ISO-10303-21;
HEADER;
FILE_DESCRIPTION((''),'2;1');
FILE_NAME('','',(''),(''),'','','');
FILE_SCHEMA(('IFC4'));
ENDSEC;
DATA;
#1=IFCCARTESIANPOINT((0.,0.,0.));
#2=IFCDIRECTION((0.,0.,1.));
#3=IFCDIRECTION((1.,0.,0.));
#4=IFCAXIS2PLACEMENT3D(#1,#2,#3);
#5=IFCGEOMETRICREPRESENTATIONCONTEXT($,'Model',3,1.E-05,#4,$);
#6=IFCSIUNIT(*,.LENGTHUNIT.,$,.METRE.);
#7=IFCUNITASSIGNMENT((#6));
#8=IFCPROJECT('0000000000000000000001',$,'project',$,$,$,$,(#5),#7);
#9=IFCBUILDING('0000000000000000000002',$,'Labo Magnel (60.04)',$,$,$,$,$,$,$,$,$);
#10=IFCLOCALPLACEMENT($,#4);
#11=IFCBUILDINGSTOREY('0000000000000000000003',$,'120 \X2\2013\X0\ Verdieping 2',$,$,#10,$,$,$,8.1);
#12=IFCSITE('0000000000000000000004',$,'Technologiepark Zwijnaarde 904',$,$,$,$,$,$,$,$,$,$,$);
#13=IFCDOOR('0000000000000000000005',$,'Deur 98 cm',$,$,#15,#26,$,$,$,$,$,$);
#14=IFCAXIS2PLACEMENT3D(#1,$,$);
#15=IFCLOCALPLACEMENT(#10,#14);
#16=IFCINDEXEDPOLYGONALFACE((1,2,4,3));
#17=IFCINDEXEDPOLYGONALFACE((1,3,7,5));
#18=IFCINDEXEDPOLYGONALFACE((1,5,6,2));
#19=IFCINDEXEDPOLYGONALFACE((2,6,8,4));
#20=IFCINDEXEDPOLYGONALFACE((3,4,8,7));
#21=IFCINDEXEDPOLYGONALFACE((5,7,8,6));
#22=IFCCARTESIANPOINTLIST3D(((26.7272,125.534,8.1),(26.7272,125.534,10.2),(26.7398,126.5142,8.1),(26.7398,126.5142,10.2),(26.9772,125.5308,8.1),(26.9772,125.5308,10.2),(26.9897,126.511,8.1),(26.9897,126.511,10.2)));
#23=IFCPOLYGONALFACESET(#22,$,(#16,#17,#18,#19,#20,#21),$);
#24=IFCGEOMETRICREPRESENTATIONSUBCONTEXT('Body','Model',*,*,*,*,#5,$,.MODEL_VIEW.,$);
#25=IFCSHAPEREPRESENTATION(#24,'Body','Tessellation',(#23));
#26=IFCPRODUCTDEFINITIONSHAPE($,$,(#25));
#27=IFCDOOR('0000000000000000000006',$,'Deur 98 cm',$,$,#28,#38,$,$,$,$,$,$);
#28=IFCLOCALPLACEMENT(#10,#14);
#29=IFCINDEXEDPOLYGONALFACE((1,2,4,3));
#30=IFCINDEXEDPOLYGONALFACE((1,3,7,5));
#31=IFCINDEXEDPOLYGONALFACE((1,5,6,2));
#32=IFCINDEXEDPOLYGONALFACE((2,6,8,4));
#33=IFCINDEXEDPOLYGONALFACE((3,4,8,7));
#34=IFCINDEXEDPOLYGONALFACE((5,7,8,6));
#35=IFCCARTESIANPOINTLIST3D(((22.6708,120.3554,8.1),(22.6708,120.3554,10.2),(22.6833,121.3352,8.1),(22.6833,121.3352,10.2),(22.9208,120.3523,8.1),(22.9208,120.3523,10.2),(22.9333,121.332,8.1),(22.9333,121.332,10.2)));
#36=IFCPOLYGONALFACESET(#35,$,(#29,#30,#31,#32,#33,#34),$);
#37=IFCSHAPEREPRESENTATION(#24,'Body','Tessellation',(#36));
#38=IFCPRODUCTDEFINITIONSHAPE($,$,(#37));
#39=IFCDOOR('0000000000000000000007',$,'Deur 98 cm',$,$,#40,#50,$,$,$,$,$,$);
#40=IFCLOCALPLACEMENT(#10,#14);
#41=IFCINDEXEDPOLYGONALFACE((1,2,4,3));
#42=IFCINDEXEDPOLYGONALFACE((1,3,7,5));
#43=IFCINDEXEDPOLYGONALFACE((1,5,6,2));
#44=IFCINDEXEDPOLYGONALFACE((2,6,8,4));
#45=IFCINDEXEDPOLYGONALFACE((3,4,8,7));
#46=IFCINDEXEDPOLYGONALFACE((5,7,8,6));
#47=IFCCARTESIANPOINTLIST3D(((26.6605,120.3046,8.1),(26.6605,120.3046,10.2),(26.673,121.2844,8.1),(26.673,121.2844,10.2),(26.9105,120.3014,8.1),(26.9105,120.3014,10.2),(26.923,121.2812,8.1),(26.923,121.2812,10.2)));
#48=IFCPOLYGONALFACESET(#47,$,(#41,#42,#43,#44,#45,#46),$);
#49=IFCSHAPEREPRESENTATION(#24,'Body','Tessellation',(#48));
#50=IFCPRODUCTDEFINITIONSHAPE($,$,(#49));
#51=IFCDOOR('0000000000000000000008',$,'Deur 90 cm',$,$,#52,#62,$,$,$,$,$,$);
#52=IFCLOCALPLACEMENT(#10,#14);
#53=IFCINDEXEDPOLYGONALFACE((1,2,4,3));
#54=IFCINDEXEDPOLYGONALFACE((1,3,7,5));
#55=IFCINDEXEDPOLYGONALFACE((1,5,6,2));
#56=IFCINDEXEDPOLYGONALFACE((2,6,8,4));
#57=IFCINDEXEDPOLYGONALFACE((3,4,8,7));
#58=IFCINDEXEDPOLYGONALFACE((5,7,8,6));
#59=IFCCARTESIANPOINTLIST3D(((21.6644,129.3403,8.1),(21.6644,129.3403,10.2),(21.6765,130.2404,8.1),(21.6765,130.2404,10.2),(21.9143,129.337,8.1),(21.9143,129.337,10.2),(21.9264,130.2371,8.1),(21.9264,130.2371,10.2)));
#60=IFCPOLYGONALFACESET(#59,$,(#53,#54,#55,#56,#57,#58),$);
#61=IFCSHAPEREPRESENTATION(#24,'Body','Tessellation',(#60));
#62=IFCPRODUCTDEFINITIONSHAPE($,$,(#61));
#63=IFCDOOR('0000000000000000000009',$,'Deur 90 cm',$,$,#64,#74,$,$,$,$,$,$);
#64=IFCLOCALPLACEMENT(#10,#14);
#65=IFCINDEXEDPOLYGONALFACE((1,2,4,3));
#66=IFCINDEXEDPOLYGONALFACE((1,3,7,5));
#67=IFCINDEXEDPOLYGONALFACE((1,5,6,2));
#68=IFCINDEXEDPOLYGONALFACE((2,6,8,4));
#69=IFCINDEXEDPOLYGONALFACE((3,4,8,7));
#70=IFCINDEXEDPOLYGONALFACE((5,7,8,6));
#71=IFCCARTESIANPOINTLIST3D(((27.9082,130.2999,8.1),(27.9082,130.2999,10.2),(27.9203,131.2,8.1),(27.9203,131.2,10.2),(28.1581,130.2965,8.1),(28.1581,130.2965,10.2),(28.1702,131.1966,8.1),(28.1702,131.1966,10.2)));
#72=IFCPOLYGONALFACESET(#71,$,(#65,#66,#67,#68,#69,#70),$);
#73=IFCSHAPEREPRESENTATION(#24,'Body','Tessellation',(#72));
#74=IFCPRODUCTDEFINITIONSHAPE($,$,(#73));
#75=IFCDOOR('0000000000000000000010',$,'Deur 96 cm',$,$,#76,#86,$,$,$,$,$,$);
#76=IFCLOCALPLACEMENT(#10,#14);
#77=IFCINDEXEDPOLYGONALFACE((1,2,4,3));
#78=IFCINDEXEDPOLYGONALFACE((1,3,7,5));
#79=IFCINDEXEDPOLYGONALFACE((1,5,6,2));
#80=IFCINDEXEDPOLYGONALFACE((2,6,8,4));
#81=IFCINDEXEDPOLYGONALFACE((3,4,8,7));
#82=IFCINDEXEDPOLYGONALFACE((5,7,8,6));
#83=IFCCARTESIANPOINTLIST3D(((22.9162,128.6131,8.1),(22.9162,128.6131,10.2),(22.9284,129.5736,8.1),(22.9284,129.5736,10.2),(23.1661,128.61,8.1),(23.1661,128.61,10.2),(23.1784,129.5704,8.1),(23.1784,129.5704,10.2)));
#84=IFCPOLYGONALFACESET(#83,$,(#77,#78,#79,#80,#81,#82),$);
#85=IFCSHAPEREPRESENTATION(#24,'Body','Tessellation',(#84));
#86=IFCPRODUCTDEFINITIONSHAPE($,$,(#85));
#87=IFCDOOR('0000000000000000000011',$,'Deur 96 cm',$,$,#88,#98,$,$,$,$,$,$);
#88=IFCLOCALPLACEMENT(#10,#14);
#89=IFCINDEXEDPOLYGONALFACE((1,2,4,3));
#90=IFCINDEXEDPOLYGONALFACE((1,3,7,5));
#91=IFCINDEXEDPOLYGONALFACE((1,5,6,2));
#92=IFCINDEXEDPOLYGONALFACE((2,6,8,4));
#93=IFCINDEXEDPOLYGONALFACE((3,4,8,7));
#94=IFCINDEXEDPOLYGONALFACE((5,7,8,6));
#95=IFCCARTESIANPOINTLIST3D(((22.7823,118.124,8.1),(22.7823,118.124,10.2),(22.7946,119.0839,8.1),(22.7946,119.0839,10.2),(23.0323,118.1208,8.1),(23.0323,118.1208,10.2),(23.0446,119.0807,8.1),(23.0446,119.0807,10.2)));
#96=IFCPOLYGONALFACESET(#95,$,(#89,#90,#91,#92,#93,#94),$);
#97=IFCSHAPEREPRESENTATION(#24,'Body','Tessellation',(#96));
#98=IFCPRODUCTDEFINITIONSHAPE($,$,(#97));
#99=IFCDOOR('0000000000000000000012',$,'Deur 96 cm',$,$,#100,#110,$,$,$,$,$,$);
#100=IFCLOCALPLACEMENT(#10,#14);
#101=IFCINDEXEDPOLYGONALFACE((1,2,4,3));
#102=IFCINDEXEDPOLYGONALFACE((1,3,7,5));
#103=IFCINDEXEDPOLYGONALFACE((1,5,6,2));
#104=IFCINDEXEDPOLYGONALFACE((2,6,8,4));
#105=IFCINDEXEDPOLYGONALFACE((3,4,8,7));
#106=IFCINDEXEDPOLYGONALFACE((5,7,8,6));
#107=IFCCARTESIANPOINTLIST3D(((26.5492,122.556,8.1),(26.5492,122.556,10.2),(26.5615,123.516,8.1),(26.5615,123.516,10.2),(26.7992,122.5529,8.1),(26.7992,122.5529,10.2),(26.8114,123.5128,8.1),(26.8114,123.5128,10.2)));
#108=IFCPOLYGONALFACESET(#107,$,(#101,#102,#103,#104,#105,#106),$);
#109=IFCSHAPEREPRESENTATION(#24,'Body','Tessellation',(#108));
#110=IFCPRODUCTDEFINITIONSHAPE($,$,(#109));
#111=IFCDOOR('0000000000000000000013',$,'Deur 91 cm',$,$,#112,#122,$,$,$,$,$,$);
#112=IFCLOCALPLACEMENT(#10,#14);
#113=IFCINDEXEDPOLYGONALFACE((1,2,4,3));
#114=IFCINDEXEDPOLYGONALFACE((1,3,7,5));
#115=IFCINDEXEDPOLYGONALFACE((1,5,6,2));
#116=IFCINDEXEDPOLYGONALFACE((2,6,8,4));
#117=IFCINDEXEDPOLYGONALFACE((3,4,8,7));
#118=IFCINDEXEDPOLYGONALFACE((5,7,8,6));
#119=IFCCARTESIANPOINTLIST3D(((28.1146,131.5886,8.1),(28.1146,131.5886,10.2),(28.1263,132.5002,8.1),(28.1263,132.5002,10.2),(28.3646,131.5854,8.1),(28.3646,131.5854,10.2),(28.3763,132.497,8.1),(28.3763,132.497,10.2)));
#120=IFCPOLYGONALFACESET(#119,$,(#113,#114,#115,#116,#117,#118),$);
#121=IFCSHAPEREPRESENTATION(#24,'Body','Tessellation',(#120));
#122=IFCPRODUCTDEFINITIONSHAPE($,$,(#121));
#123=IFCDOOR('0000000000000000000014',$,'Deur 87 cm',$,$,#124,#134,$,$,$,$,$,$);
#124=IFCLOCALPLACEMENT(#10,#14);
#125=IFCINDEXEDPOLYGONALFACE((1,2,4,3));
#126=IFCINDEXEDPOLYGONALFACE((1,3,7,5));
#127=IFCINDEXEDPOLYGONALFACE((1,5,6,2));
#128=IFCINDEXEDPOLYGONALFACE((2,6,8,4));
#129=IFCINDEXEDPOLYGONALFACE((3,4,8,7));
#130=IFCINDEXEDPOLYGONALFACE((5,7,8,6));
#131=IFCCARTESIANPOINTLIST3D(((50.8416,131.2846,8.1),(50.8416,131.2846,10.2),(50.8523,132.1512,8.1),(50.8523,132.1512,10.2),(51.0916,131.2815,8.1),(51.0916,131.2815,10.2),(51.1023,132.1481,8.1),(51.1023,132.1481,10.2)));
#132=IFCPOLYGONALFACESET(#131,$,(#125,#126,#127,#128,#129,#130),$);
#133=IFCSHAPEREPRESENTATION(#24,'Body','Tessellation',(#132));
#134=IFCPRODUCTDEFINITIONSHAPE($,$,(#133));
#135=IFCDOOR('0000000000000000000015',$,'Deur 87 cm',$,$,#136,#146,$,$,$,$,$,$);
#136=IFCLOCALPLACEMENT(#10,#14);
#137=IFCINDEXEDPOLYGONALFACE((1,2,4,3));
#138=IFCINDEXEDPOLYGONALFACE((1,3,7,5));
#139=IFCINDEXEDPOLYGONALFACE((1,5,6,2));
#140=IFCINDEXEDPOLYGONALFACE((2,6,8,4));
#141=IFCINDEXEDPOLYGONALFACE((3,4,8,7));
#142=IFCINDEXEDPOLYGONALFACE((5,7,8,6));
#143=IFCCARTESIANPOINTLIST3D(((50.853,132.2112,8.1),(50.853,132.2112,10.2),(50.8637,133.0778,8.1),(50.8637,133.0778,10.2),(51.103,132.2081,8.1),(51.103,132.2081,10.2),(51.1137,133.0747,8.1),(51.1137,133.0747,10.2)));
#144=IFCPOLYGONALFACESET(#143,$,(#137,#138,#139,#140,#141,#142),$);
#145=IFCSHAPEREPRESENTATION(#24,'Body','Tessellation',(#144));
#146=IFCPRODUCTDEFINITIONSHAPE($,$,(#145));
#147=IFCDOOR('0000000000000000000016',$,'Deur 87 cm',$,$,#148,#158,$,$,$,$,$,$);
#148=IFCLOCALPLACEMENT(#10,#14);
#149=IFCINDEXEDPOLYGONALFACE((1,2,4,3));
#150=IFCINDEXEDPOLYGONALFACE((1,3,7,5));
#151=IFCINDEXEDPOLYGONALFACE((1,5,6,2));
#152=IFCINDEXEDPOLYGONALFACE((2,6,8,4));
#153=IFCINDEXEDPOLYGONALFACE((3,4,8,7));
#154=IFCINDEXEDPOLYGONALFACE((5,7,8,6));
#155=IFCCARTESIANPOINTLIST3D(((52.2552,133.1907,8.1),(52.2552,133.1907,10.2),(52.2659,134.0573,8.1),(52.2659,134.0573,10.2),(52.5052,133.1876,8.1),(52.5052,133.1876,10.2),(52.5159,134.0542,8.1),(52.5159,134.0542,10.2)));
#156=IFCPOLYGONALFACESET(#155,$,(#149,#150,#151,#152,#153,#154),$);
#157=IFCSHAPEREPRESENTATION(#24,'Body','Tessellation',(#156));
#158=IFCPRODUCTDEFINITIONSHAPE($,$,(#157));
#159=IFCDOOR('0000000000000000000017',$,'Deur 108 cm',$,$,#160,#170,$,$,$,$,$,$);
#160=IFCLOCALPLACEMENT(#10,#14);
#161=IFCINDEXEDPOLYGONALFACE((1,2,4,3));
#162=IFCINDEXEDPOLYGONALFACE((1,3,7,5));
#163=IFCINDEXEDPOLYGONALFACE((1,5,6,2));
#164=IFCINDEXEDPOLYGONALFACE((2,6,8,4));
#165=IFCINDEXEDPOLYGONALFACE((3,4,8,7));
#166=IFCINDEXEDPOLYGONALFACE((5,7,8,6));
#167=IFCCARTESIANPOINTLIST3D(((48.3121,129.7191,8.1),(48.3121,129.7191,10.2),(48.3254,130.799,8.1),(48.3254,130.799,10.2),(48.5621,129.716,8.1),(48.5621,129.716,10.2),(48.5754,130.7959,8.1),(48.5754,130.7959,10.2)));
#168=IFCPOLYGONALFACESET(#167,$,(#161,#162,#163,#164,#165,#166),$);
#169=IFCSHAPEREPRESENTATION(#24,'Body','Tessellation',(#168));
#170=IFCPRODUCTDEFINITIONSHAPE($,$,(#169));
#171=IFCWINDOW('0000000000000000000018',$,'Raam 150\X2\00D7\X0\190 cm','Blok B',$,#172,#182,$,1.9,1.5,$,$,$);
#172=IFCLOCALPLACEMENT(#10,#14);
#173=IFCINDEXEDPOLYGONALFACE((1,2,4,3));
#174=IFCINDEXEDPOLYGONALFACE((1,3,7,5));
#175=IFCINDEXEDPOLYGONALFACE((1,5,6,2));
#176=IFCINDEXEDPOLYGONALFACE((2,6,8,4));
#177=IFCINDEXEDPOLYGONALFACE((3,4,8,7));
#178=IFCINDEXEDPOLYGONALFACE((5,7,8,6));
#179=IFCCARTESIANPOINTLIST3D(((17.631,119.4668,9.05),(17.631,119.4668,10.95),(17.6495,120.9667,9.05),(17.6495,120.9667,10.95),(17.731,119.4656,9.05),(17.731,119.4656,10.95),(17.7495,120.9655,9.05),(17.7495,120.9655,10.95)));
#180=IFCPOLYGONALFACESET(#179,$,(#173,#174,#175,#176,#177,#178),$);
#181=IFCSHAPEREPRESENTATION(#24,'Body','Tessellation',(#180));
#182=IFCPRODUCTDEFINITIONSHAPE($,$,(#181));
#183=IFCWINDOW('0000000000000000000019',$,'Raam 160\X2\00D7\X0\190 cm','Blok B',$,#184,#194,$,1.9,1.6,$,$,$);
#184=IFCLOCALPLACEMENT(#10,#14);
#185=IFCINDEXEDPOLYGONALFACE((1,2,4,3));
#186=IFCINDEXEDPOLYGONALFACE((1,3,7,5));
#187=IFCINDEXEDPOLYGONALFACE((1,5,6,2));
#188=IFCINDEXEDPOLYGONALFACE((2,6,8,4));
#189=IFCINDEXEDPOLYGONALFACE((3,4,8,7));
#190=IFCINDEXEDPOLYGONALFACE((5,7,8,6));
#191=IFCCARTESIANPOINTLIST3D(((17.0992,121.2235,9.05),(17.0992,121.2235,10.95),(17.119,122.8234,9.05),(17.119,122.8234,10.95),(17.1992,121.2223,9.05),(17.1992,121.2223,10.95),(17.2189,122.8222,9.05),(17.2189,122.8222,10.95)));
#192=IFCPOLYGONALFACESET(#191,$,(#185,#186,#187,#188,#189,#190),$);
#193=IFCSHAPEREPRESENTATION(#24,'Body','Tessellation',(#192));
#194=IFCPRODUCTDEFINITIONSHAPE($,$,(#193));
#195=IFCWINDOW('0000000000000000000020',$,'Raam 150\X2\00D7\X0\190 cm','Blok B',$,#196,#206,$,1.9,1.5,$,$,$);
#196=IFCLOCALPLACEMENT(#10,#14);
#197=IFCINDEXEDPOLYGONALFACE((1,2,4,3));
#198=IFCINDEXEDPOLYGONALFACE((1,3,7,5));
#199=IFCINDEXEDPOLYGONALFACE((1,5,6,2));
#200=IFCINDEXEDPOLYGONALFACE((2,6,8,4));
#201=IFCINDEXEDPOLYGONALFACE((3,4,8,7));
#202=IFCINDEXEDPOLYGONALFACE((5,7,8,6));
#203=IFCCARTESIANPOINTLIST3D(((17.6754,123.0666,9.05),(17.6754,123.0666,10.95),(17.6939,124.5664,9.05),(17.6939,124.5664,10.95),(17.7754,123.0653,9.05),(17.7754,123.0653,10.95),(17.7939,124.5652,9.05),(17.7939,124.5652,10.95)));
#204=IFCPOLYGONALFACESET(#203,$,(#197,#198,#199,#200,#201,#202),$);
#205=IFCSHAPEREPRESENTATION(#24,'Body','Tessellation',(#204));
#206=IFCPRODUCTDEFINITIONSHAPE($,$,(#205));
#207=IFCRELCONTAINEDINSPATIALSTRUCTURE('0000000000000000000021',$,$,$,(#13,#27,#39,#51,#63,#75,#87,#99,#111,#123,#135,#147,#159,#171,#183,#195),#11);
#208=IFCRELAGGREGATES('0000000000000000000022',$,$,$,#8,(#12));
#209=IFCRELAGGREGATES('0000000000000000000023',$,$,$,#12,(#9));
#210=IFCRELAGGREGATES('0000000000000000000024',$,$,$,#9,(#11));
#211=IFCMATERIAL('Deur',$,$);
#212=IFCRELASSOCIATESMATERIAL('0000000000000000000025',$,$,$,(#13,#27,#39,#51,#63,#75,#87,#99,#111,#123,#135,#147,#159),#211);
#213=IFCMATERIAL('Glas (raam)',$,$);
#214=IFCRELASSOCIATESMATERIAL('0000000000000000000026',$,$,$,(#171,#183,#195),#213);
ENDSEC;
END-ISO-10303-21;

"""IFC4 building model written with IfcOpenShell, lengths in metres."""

from ifc_helpers import new_model, si_unit, frame, origin, origin_with_axes, place, context, subcontext, project, spatial, polyline, outline, extrude, material, element, save


model = new_model("IFC4")

# Units and contexts
model_context = context("Model", 3, precision=1e-05, world=origin_with_axes())
body_context = subcontext(model_context, "Body", "Model", "MODEL_VIEW")
ifc_project = project(units=[si_unit("LENGTHUNIT", "METRE")], contexts=[model_context])

# Site, building, storey
site = spatial("IfcSite", under=ifc_project, Name="Technologiepark Zwijnaarde 904")
building = spatial("IfcBuilding", under=site, Name="Labo Magnel (60.04)")
storey_placement = place(None, origin_with_axes())
storey = spatial("IfcBuildingStorey", under=building, at=storey_placement, Name="120 – Verdieping 2", Elevation=8.1)

# Doors
ifc_material_1 = material(Name="Deur")
door_1_placement = place(storey_placement, frame((26.8522, 125.5324, 8.1), z_axis=(0.0, 0.0, 1.0), x_axis=(0.012764, 0.999919, 0.0)))
element("IfcDoor", 1, at=door_1_placement, inside=storey, material=ifc_material_1, Name="Deur 98 cm", context=body_context, shape_type="SweptSolid", body=[
    extrude(outline(polyline([(0.0, -0.125), (0.9802, -0.125), (0.9802, 0.125), (0.0, 0.125), (0.0, -0.125)])), origin(), (0.0, 0.0, 1.0), 2.1),
])
for number, where, z_axis, x_axis, name in (
    (2, (22.8083, 121.3336, 8.1), (0.0, 0.0, 1.0), (-0.012764, -0.999919, 0.0), "Deur 98 cm"),
    (3, (26.798, 121.2828, 8.1), (0.0, 0.0, 1.0), (-0.012764, -0.999919, 0.0), "Deur 98 cm"),
):
    element("IfcDoor", number, at=place(storey_placement, frame(where, z_axis=z_axis, x_axis=x_axis)), inside=storey, material=ifc_material_1, Name=name, context=body_context, shape_type="SweptSolid", body=[
        extrude(outline(polyline([(0.0, -0.125), (0.9798, -0.125), (0.9798, 0.125), (0.0, 0.125), (0.0, -0.125)])), origin(), (0.0, 0.0, 1.0), 2.1),
    ])
door_2_placement = place(storey_placement, frame((21.8015, 130.2387, 8.1), z_axis=(0.0, 0.0, 1.0), x_axis=(-0.013442, -0.99991, 0.0)))
element("IfcDoor", 4, at=door_2_placement, inside=storey, material=ifc_material_1, Name="Deur 90 cm", context=body_context, shape_type="SweptSolid", body=[
    extrude(outline(polyline([(0.0, -0.125), (0.9002, -0.125), (0.9002, 0.125), (0.0, 0.125), (0.0, -0.125)])), origin(), (0.0, 0.0, 1.0), 2.1),
])
door_3_placement = place(storey_placement, frame((28.0332, 130.2982, 8.1), z_axis=(0.0, 0.0, 1.0), x_axis=(0.013442, 0.99991, 0.0)))
element("IfcDoor", 5, at=door_3_placement, inside=storey, material=ifc_material_1, Name="Deur 90 cm", context=body_context, shape_type="SweptSolid", body=[
    extrude(outline(polyline([(0.0, -0.125), (0.9002, -0.125), (0.9002, 0.125), (0.0, 0.125), (0.0, -0.125)])), origin(), (0.0, 0.0, 1.0), 2.1),
])
door_4_placement = place(storey_placement, frame((23.0534, 129.572, 8.1), z_axis=(0.0, 0.0, 1.0), x_axis=(-0.012764, -0.999919, 0.0)))
element("IfcDoor", 6, at=door_4_placement, inside=storey, material=ifc_material_1, Name="Deur 96 cm", context=body_context, shape_type="SweptSolid", body=[
    extrude(outline(polyline([(0.0, -0.125), (0.9605, -0.125), (0.9605, 0.125), (0.0, 0.125), (0.0, -0.125)])), origin(), (0.0, 0.0, 1.0), 2.1),
])
for number, where, z_axis, x_axis, name in (
    (7, (22.9073, 118.1224, 8.1), (0.0, 0.0, 1.0), (0.012764, 0.999919, 0.0), "Deur 96 cm"),
    (8, (26.6742, 122.5544, 8.1), (0.0, 0.0, 1.0), (0.012764, 0.999919, 0.0), "Deur 96 cm"),
):
    element("IfcDoor", number, at=place(storey_placement, frame(where, z_axis=z_axis, x_axis=x_axis)), inside=storey, material=ifc_material_1, Name=name, context=body_context, shape_type="SweptSolid", body=[
        extrude(outline(polyline([(0.0, -0.125), (0.96, -0.125), (0.96, 0.125), (0.0, 0.125), (0.0, -0.125)])), origin(), (0.0, 0.0, 1.0), 2.1),
    ])
door_5_placement = place(storey_placement, frame((28.2513, 132.4986, 8.1), z_axis=(0.0, 0.0, 1.0), x_axis=(-0.012764, -0.999919, 0.0)))
element("IfcDoor", 9, at=door_5_placement, inside=storey, material=ifc_material_1, Name="Deur 91 cm", context=body_context, shape_type="SweptSolid", body=[
    extrude(outline(polyline([(0.0, -0.125), (0.9116, -0.125), (0.9116, 0.125), (0.0, 0.125), (0.0, -0.125)])), origin(), (0.0, 0.0, 1.0), 2.1),
])
for number, where, z_axis, x_axis, name in (
    (10, (50.9666, 131.2831, 8.1), (0.0, 0.0, 1.0), (0.012338, 0.999924, 0.0), "Deur 87 cm"),
    (11, (50.978, 132.2097, 8.1), (0.0, 0.0, 1.0), (0.012338, 0.999924, 0.0), "Deur 87 cm"),
    (12, (52.3802, 133.1891, 8.1), (0.0, 0.0, 1.0), (0.012338, 0.999924, 0.0), "Deur 87 cm"),
):
    element("IfcDoor", number, at=place(storey_placement, frame(where, z_axis=z_axis, x_axis=x_axis)), inside=storey, material=ifc_material_1, Name=name, context=body_context, shape_type="SweptSolid", body=[
        extrude(outline(polyline([(0.0, -0.125), (0.8667, -0.125), (0.8667, 0.125), (0.0, 0.125), (0.0, -0.125)])), origin(), (0.0, 0.0, 1.0), 2.1),
    ])
door_6_placement = place(storey_placement, frame((48.4371, 129.7175, 8.1), z_axis=(0.0, 0.0, 1.0), x_axis=(0.012338, 0.999924, 0.0)))
element("IfcDoor", 13, at=door_6_placement, inside=storey, material=ifc_material_1, Name="Deur 108 cm", context=body_context, shape_type="SweptSolid", body=[
    extrude(outline(polyline([(0.0, -0.125), (1.08, -0.125), (1.08, 0.125), (0.0, 0.125), (0.0, -0.125)])), origin(), (0.0, 0.0, 1.0), 2.1),
])

# Windows
ifc_material_2 = material(Name="Glas (raam)")
window_1_placement = place(storey_placement, frame((17.681, 119.4662, 9.05), z_axis=(0.0, 0.0, 1.0), x_axis=(0.012338, 0.999924, 0.0)))
element("IfcWindow", 14, at=window_1_placement, inside=storey, material=ifc_material_2, Name="Raam 150×190 cm", Description="Blok B", OverallHeight=1.9, OverallWidth=1.5, context=body_context, shape_type="SweptSolid", body=[
    extrude(outline(polyline([(0.0, -0.05), (1.5, -0.05), (1.5, 0.05), (0.0, 0.05), (0.0, -0.05)])), origin(), (0.0, 0.0, 1.0), 1.9),
])
window_2_placement = place(storey_placement, frame((17.1492, 121.2229, 9.05), z_axis=(0.0, 0.0, 1.0), x_axis=(0.012338, 0.999924, 0.0)))
element("IfcWindow", 15, at=window_2_placement, inside=storey, material=ifc_material_2, Name="Raam 160×190 cm", Description="Blok B", OverallHeight=1.9, OverallWidth=1.6, context=body_context, shape_type="SweptSolid", body=[
    extrude(outline(polyline([(0.0, -0.05), (1.6, -0.05), (1.6, 0.05), (0.0, 0.05), (0.0, -0.05)])), origin(), (0.0, 0.0, 1.0), 1.9),
])
window_3_placement = place(storey_placement, frame((17.7439, 124.5658, 9.05), z_axis=(0.0, 0.0, 1.0), x_axis=(-0.012338, -0.999924, 0.0)))
element("IfcWindow", 16, at=window_3_placement, inside=storey, material=ifc_material_2, Name="Raam 150×190 cm", Description="Blok B", OverallHeight=1.9, OverallWidth=1.5, context=body_context, shape_type="SweptSolid", body=[
    extrude(outline(polyline([(0.0, -0.05), (1.5, -0.05), (1.5, 0.05), (0.0, 0.05), (0.0, -0.05)])), origin(), (0.0, 0.0, 1.0), 1.9),
])

save(model, "model.ifc")
